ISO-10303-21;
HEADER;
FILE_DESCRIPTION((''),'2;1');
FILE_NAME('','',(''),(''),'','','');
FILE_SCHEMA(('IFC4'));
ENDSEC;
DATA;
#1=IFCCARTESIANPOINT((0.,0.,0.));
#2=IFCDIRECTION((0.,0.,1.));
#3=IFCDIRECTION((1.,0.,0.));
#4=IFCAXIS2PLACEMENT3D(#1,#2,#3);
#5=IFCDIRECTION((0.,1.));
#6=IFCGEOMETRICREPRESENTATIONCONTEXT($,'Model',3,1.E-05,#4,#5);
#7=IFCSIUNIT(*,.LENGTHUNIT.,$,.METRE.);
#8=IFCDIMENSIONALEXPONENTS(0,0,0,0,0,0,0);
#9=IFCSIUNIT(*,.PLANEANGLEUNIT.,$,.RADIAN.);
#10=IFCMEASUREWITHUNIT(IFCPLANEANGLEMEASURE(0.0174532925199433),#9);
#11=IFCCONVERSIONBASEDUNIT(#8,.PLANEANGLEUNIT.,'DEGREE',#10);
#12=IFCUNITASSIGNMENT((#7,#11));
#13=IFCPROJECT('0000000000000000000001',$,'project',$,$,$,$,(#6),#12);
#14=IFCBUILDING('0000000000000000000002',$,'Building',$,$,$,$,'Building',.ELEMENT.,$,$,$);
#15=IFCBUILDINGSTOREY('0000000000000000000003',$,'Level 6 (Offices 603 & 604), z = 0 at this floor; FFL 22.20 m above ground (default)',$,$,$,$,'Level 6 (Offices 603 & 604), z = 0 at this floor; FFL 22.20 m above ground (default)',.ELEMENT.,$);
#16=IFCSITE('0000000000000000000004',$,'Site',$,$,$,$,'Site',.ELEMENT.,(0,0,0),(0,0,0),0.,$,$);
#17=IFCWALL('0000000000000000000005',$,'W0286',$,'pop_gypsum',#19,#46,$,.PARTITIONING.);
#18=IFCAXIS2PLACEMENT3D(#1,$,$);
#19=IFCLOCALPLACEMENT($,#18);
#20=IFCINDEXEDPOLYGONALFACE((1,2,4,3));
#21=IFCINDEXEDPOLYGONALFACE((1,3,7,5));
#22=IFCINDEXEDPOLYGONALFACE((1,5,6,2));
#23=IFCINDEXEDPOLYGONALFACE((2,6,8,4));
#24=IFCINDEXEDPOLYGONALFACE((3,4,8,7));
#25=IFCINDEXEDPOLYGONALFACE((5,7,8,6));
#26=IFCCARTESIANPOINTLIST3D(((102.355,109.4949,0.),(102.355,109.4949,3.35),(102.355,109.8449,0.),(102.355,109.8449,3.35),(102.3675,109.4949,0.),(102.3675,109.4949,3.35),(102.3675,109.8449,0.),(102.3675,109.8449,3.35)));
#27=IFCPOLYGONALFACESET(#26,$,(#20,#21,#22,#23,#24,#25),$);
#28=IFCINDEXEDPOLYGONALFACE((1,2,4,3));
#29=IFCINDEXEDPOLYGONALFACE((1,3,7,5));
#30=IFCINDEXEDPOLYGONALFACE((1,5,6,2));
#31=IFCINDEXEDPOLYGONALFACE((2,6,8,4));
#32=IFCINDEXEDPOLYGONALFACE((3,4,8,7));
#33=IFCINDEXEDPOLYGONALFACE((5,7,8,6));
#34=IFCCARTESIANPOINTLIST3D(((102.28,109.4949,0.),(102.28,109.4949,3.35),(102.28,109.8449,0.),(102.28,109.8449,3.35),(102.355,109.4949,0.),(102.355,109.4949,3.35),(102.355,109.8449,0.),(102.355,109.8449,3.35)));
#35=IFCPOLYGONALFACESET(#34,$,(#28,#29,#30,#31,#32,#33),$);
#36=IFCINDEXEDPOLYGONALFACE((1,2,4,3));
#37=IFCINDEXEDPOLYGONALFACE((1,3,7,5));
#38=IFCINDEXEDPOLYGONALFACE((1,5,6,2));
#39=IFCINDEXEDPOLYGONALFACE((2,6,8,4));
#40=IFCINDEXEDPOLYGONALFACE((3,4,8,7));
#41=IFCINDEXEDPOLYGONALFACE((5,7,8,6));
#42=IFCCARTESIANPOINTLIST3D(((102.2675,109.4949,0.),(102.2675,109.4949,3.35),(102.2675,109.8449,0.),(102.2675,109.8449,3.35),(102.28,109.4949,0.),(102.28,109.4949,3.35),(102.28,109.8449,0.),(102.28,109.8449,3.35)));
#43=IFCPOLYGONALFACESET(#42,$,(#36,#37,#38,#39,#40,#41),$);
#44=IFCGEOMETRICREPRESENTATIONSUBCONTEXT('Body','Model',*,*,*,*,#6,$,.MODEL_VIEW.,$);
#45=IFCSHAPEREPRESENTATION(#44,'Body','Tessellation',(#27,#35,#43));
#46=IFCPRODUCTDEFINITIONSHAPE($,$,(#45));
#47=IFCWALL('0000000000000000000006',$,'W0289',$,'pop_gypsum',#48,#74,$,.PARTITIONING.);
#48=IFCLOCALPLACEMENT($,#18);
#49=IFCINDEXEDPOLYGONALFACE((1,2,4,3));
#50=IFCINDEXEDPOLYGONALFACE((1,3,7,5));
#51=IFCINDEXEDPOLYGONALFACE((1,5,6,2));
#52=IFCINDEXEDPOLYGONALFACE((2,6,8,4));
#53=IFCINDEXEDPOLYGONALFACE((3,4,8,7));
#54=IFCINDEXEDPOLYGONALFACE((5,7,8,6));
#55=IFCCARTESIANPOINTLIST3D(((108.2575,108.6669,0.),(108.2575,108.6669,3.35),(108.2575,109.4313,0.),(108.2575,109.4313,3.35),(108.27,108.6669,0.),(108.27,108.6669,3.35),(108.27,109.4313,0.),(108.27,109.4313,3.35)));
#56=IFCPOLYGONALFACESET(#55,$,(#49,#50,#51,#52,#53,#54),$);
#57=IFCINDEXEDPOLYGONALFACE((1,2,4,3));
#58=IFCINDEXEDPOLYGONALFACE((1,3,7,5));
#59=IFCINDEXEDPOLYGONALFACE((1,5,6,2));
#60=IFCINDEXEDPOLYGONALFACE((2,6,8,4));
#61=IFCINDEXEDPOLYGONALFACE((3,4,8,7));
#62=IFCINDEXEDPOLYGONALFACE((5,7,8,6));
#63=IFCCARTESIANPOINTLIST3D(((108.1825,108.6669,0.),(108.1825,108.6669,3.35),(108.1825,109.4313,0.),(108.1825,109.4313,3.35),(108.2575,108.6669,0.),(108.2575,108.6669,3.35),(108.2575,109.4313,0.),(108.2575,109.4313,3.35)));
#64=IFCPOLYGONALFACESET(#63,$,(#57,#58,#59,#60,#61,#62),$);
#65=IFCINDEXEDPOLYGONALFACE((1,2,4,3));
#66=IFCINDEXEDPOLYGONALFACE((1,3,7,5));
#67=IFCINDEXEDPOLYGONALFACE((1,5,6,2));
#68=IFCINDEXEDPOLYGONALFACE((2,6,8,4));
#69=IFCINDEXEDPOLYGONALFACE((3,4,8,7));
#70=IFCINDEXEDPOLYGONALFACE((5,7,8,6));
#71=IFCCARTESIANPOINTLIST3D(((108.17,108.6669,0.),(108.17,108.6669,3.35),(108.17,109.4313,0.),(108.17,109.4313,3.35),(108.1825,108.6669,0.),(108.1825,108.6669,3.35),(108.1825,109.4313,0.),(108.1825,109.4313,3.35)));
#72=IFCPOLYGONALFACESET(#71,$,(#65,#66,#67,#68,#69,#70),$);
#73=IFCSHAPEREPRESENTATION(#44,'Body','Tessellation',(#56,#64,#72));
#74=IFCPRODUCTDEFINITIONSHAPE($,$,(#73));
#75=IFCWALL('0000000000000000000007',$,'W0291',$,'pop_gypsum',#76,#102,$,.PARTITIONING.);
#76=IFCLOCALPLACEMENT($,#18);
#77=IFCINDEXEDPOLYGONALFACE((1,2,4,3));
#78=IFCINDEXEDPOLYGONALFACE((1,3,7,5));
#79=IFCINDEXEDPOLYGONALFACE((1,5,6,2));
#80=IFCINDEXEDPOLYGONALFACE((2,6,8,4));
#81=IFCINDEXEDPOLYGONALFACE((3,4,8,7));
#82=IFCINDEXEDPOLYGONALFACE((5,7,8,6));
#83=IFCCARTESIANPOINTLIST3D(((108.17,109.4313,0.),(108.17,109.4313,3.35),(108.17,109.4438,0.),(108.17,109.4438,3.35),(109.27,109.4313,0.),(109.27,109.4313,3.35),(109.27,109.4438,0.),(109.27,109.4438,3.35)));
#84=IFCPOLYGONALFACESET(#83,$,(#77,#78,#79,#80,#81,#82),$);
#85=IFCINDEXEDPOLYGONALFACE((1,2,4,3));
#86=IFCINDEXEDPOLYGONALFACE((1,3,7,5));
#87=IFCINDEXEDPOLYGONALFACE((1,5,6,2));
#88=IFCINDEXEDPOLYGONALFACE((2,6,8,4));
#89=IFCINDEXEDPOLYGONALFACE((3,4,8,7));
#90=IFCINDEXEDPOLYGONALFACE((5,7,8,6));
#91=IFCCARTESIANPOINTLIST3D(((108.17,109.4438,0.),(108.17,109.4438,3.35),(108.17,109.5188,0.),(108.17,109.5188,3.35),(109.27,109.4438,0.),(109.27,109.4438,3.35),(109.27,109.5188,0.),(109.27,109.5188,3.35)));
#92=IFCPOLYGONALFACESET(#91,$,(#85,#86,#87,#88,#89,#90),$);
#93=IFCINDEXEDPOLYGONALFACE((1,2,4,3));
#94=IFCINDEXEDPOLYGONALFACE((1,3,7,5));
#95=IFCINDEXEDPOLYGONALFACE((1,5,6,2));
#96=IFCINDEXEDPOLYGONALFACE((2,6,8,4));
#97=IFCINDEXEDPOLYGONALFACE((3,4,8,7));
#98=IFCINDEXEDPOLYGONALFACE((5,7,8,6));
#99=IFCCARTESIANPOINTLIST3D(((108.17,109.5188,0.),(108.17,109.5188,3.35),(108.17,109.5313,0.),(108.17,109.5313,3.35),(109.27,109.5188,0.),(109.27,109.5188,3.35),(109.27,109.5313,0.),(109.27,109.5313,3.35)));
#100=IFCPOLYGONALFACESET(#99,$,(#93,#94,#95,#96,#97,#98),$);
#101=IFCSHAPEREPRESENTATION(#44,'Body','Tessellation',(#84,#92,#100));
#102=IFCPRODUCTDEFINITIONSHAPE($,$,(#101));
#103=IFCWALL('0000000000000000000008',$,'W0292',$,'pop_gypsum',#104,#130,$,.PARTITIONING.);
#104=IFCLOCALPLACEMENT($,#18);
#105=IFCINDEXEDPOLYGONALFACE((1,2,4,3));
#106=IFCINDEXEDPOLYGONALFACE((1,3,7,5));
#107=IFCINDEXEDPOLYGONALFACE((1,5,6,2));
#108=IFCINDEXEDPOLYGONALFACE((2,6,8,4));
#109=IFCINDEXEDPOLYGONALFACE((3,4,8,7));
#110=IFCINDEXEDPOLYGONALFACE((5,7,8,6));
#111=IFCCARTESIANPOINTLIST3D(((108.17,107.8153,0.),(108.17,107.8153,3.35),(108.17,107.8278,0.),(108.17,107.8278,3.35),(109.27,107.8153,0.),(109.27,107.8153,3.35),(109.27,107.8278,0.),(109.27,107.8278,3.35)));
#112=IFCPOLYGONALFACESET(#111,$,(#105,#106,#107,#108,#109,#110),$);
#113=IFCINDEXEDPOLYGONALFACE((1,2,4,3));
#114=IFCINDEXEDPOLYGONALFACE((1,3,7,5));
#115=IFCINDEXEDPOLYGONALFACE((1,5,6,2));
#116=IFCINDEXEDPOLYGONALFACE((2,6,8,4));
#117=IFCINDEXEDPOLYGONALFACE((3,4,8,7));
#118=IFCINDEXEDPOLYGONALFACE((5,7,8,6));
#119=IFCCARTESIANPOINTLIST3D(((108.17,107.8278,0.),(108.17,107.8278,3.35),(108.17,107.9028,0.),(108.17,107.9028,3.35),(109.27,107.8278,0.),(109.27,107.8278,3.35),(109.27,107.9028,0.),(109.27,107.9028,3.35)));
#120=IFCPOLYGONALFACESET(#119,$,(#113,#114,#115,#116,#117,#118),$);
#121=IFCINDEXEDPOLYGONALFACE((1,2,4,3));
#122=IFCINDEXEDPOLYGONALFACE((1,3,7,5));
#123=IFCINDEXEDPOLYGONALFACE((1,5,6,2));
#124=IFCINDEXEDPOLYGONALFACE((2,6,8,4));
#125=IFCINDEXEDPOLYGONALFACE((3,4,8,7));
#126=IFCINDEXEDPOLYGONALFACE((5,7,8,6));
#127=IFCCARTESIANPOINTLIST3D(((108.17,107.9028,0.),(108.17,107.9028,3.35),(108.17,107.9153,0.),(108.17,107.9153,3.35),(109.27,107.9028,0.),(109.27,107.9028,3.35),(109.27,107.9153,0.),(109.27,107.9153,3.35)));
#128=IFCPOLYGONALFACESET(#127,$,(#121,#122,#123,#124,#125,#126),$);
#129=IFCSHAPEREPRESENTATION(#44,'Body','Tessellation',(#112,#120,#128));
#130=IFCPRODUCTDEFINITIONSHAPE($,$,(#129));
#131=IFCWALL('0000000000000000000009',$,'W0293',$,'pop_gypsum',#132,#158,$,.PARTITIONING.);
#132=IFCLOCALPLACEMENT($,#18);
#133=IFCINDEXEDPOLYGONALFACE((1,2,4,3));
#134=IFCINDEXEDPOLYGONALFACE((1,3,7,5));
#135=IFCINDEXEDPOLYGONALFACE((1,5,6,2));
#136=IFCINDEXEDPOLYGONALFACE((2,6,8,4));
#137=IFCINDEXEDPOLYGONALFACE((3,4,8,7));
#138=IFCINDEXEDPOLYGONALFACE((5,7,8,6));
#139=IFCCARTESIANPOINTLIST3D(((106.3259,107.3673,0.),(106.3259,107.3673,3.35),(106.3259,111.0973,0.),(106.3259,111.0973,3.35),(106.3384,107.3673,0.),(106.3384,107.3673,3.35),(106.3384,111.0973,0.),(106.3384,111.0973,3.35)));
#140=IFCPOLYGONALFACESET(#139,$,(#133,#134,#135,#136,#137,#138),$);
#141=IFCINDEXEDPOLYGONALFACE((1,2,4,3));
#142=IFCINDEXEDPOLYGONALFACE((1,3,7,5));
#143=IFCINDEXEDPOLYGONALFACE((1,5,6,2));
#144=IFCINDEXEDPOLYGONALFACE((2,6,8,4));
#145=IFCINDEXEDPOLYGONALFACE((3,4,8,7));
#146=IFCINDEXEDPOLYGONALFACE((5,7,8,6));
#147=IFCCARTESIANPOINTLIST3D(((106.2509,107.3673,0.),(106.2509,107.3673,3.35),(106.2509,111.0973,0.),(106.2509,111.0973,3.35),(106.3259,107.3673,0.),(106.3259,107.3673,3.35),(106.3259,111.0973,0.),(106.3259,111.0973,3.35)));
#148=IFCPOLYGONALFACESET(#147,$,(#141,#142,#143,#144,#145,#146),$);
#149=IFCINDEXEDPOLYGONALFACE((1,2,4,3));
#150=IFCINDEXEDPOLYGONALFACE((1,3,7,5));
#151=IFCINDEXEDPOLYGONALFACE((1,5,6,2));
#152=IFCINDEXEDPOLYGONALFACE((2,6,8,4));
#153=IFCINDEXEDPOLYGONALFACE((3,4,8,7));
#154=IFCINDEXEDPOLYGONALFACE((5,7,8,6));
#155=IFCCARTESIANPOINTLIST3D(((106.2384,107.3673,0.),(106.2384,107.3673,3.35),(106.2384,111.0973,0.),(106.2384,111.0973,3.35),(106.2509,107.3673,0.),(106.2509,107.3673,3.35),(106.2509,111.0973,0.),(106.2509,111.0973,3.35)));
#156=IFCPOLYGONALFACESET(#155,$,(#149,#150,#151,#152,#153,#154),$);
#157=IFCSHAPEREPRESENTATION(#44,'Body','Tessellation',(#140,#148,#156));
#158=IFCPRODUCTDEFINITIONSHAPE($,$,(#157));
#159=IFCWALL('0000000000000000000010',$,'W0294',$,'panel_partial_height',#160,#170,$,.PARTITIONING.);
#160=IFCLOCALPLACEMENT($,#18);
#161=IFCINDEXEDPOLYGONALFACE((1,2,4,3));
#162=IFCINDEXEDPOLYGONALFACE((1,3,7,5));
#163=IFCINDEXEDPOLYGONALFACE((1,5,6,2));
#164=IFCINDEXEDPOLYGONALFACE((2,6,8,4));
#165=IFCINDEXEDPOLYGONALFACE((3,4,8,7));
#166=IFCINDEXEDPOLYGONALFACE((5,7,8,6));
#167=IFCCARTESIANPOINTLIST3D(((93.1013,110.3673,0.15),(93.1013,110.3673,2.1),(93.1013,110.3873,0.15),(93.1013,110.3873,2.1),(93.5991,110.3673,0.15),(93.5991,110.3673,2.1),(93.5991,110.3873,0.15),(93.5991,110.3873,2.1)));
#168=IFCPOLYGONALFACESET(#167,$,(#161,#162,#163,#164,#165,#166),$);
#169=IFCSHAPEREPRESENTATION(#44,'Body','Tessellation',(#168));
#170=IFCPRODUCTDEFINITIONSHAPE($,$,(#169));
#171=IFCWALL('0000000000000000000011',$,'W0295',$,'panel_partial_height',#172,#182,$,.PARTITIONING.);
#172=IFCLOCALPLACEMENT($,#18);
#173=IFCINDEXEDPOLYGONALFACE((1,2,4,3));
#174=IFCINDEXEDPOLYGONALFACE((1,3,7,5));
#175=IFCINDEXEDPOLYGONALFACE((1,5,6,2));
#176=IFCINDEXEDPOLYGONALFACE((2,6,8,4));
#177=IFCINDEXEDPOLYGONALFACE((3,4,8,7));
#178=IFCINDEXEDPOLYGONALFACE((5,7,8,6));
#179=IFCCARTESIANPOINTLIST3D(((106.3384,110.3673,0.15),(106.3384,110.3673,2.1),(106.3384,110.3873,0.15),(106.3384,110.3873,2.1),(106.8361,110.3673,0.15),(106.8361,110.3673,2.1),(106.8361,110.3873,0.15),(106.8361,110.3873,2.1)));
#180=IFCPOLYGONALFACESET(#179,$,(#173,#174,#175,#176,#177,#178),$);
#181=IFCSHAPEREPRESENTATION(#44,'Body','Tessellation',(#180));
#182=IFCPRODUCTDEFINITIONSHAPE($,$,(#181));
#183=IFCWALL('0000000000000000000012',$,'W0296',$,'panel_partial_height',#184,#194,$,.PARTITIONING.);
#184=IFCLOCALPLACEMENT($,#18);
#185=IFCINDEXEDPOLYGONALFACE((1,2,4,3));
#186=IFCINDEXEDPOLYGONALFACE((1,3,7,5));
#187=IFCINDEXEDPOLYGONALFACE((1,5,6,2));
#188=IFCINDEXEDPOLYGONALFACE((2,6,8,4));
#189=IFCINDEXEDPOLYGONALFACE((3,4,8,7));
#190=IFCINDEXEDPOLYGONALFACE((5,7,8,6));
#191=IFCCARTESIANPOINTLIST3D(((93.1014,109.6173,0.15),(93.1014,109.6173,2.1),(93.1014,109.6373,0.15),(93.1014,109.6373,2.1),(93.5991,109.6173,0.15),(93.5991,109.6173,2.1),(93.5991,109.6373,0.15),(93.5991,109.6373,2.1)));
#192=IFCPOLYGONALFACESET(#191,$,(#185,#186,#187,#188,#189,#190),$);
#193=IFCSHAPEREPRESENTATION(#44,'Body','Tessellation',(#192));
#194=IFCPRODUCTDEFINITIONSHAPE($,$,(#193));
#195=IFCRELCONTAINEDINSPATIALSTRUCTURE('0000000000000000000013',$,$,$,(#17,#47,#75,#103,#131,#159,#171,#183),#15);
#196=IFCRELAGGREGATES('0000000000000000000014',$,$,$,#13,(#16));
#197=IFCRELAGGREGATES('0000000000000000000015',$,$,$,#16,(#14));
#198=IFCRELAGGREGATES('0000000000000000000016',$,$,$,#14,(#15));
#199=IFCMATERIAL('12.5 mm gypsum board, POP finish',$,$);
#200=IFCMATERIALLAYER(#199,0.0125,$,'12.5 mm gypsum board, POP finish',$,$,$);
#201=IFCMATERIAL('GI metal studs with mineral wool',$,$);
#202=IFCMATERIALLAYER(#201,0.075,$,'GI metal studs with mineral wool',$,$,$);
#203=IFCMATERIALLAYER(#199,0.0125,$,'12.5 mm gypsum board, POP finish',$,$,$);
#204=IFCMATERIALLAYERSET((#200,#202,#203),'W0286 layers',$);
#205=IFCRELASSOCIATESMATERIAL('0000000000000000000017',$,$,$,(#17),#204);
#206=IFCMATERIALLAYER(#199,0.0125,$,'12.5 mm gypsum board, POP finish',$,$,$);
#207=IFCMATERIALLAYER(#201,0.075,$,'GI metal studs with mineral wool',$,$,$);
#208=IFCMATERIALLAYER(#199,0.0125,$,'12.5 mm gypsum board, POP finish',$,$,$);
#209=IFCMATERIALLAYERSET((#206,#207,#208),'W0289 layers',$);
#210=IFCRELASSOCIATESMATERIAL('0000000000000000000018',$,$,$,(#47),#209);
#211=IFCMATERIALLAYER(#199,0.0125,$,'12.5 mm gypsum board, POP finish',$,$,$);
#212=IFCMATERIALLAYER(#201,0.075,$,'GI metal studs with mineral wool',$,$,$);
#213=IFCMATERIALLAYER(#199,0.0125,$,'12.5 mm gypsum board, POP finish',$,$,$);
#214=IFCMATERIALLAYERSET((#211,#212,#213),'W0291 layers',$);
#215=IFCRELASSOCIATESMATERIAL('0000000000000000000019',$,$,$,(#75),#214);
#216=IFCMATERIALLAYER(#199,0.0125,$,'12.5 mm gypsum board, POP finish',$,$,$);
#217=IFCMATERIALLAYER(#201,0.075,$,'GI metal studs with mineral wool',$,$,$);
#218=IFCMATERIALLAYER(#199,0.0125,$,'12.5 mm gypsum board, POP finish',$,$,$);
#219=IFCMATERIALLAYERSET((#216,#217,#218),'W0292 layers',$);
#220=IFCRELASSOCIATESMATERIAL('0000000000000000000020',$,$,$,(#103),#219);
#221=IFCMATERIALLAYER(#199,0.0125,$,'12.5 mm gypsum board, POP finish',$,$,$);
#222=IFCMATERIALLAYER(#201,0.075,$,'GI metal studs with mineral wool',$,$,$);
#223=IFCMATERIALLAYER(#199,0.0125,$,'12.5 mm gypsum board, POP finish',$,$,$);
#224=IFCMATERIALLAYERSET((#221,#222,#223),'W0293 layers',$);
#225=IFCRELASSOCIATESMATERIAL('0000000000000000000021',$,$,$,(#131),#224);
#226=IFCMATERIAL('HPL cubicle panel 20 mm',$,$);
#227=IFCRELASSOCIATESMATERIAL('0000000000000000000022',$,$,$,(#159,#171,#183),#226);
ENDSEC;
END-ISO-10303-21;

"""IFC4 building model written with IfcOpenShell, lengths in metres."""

from ifc_helpers import new_model, entity, si_unit, converted_unit, direction, frame, frame_2d, origin_with_axes, origin_2d_with_axis, place, context, subcontext, project, spatial, rectangle, extrude, material, layer, layer_set, layer_usage, element, save


model = new_model("IFC4")

# Units and contexts
model_context = context("Model", 3, precision=1e-05, world=origin_with_axes(), true_north=direction((0.0, 1.0)))
body_context = subcontext(model_context, "Body", "Model", "MODEL_VIEW")
ifc_project = project(units=[si_unit("LENGTHUNIT", "METRE"), converted_unit("PLANEANGLEUNIT", "DEGREE", entity("IfcPlaneAngleMeasure", 0.0174532925199433), si_unit("PLANEANGLEUNIT", "RADIAN"), dimensions=[0, 0, 0, 0, 0, 0, 0])], contexts=[model_context])

# Site, building, storey
site = spatial("IfcSite", under=ifc_project, Name="Site", LongName="Site", CompositionType="ELEMENT", RefLatitude=(0, 0, 0), RefLongitude=(0, 0, 0), RefElevation=0.0)
building = spatial("IfcBuilding", under=site, Name="Building", LongName="Building", CompositionType="ELEMENT")
storey = spatial("IfcBuildingStorey", under=building, Name="Level 6 (Offices 603 & 604), z = 0 at this floor; FFL 22.20 m above ground (default)", LongName="Level 6 (Offices 603 & 604), z = 0 at this floor; FFL 22.20 m above ground (default)", CompositionType="ELEMENT")

# Walls
ifc_material_1 = material(Name="12.5 mm gypsum board, POP finish")
ifc_layer_1 = layer(ifc_material_1, 0.0125, Name="12.5 mm gypsum board, POP finish")
ifc_material_2 = material(Name="GI metal studs with mineral wool")
ifc_layer_2 = layer(ifc_material_2, 0.075, Name="GI metal studs with mineral wool")
ifc_layer_3 = layer(ifc_material_1, 0.0125, Name="12.5 mm gypsum board, POP finish")
ifc_layer_set_1 = layer_set([ifc_layer_1, ifc_layer_2, ifc_layer_3], Name="W0286 layers")
ifc_layer_usage_1 = layer_usage(ifc_layer_set_1, "AXIS2", "POSITIVE", -0.05)
placement = place(None, origin_with_axes())
element("IfcWall", 1, at=placement, inside=storey, material=ifc_layer_usage_1, Name="W0286", ObjectType="pop_gypsum", PredefinedType="PARTITIONING", context=body_context, shape_type="SweptSolid", body=[
    extrude(rectangle(XDim=0.35, YDim=0.0125, at=frame_2d((0.0, 0.0), x_axis=(0.0, 1.0))), frame((102.3612, 109.6699, 0.0), z_axis=(0.0, 0.0, 1.0), x_axis=(1.0, 0.0, 0.0)), (0.0, 0.0, 1.0), 3.35),
    extrude(rectangle(XDim=0.35, YDim=0.075, at=frame_2d((-0.0438, 0.0), x_axis=(0.0, 1.0))), frame((102.3612, 109.6699, 0.0), z_axis=(0.0, 0.0, 1.0), x_axis=(1.0, 0.0, 0.0)), (0.0, 0.0, 1.0), 3.35),
    extrude(rectangle(XDim=0.35, YDim=0.0125, at=frame_2d((-0.0875, 0.0), x_axis=(0.0, 1.0))), frame((102.3612, 109.6699, 0.0), z_axis=(0.0, 0.0, 1.0), x_axis=(1.0, 0.0, 0.0)), (0.0, 0.0, 1.0), 3.35),
])
ifc_layer_4 = layer(ifc_material_1, 0.0125, Name="12.5 mm gypsum board, POP finish")
ifc_layer_5 = layer(ifc_material_2, 0.075, Name="GI metal studs with mineral wool")
ifc_layer_6 = layer(ifc_material_1, 0.0125, Name="12.5 mm gypsum board, POP finish")
ifc_layer_set_2 = layer_set([ifc_layer_4, ifc_layer_5, ifc_layer_6], Name="W0289 layers")
ifc_layer_usage_2 = layer_usage(ifc_layer_set_2, "AXIS2", "POSITIVE", -0.05)
element("IfcWall", 2, at=placement, inside=storey, material=ifc_layer_usage_2, Name="W0289", ObjectType="pop_gypsum", PredefinedType="PARTITIONING", context=body_context, shape_type="SweptSolid", body=[
    extrude(rectangle(XDim=0.7644, YDim=0.0125, at=frame_2d((0.0, 0.0), x_axis=(0.0, 1.0))), frame((108.2638, 109.0491, 0.0), z_axis=(0.0, 0.0, 1.0), x_axis=(1.0, 0.0, 0.0)), (0.0, 0.0, 1.0), 3.35),
    extrude(rectangle(XDim=0.7644, YDim=0.075, at=frame_2d((-0.0437, 0.0), x_axis=(0.0, 1.0))), frame((108.2638, 109.0491, 0.0), z_axis=(0.0, 0.0, 1.0), x_axis=(1.0, 0.0, 0.0)), (0.0, 0.0, 1.0), 3.35),
    extrude(rectangle(XDim=0.7644, YDim=0.0125, at=frame_2d((-0.0875, 0.0), x_axis=(0.0, 1.0))), frame((108.2638, 109.0491, 0.0), z_axis=(0.0, 0.0, 1.0), x_axis=(1.0, 0.0, 0.0)), (0.0, 0.0, 1.0), 3.35),
])
ifc_layer_7 = layer(ifc_material_1, 0.0125, Name="12.5 mm gypsum board, POP finish")
ifc_layer_8 = layer(ifc_material_2, 0.075, Name="GI metal studs with mineral wool")
ifc_layer_9 = layer(ifc_material_1, 0.0125, Name="12.5 mm gypsum board, POP finish")
ifc_layer_set_3 = layer_set([ifc_layer_7, ifc_layer_8, ifc_layer_9], Name="W0291 layers")
ifc_layer_usage_3 = layer_usage(ifc_layer_set_3, "AXIS2", "POSITIVE", -0.05)
element("IfcWall", 3, at=placement, inside=storey, material=ifc_layer_usage_3, Name="W0291", ObjectType="pop_gypsum", PredefinedType="PARTITIONING", context=body_context, shape_type="SweptSolid", body=[
    extrude(rectangle(XDim=1.1, YDim=0.0125, at=origin_2d_with_axis()), frame((108.72, 109.4376, 0.0), z_axis=(0.0, 0.0, 1.0), x_axis=(1.0, 0.0, 0.0)), (0.0, 0.0, 1.0), 3.35),
    extrude(rectangle(XDim=1.1, YDim=0.075, at=frame_2d((0.0, 0.0437), x_axis=(1.0, 0.0))), frame((108.72, 109.4376, 0.0), z_axis=(0.0, 0.0, 1.0), x_axis=(1.0, 0.0, 0.0)), (0.0, 0.0, 1.0), 3.35),
    extrude(rectangle(XDim=1.1, YDim=0.0125, at=frame_2d((0.0, 0.0875), x_axis=(1.0, 0.0))), frame((108.72, 109.4376, 0.0), z_axis=(0.0, 0.0, 1.0), x_axis=(1.0, 0.0, 0.0)), (0.0, 0.0, 1.0), 3.35),
])
ifc_layer_10 = layer(ifc_material_1, 0.0125, Name="12.5 mm gypsum board, POP finish")
ifc_layer_11 = layer(ifc_material_2, 0.075, Name="GI metal studs with mineral wool")
ifc_layer_12 = layer(ifc_material_1, 0.0125, Name="12.5 mm gypsum board, POP finish")
ifc_layer_set_4 = layer_set([ifc_layer_10, ifc_layer_11, ifc_layer_12], Name="W0292 layers")
ifc_layer_usage_4 = layer_usage(ifc_layer_set_4, "AXIS2", "POSITIVE", -0.05)
element("IfcWall", 4, at=placement, inside=storey, material=ifc_layer_usage_4, Name="W0292", ObjectType="pop_gypsum", PredefinedType="PARTITIONING", context=body_context, shape_type="SweptSolid", body=[
    extrude(rectangle(XDim=1.1, YDim=0.0125, at=origin_2d_with_axis()), frame((108.72, 107.8216, 0.0), z_axis=(0.0, 0.0, 1.0), x_axis=(1.0, 0.0, 0.0)), (0.0, 0.0, 1.0), 3.35),
    extrude(rectangle(XDim=1.1, YDim=0.075, at=frame_2d((0.0, 0.0437), x_axis=(1.0, 0.0))), frame((108.72, 107.8216, 0.0), z_axis=(0.0, 0.0, 1.0), x_axis=(1.0, 0.0, 0.0)), (0.0, 0.0, 1.0), 3.35),
    extrude(rectangle(XDim=1.1, YDim=0.0125, at=frame_2d((0.0, 0.0875), x_axis=(1.0, 0.0))), frame((108.72, 107.8216, 0.0), z_axis=(0.0, 0.0, 1.0), x_axis=(1.0, 0.0, 0.0)), (0.0, 0.0, 1.0), 3.35),
])
ifc_layer_13 = layer(ifc_material_1, 0.0125, Name="12.5 mm gypsum board, POP finish")
ifc_layer_14 = layer(ifc_material_2, 0.075, Name="GI metal studs with mineral wool")
ifc_layer_15 = layer(ifc_material_1, 0.0125, Name="12.5 mm gypsum board, POP finish")
ifc_layer_set_5 = layer_set([ifc_layer_13, ifc_layer_14, ifc_layer_15], Name="W0293 layers")
ifc_layer_usage_5 = layer_usage(ifc_layer_set_5, "AXIS2", "POSITIVE", -0.05)
element("IfcWall", 5, at=placement, inside=storey, material=ifc_layer_usage_5, Name="W0293", ObjectType="pop_gypsum", PredefinedType="PARTITIONING", context=body_context, shape_type="SweptSolid", body=[
    extrude(rectangle(XDim=3.73, YDim=0.0125, at=frame_2d((0.0, 0.0), x_axis=(0.0, 1.0))), frame((106.3321, 109.2323, 0.0), z_axis=(0.0, 0.0, 1.0), x_axis=(1.0, 0.0, 0.0)), (0.0, 0.0, 1.0), 3.35),
    extrude(rectangle(XDim=3.73, YDim=0.075, at=frame_2d((-0.0437, 0.0), x_axis=(0.0, 1.0))), frame((106.3321, 109.2323, 0.0), z_axis=(0.0, 0.0, 1.0), x_axis=(1.0, 0.0, 0.0)), (0.0, 0.0, 1.0), 3.35),
    extrude(rectangle(XDim=3.73, YDim=0.0125, at=frame_2d((-0.0875, 0.0), x_axis=(0.0, 1.0))), frame((106.3321, 109.2323, 0.0), z_axis=(0.0, 0.0, 1.0), x_axis=(1.0, 0.0, 0.0)), (0.0, 0.0, 1.0), 3.35),
])
ifc_material_3 = material(Name="HPL cubicle panel 20 mm")
element("IfcWall", 6, at=placement, inside=storey, material=ifc_material_3, Name="W0294", ObjectType="panel_partial_height", PredefinedType="PARTITIONING", context=body_context, shape_type="SweptSolid", body=[
    extrude(rectangle(XDim=0.4978, YDim=0.02, at=origin_2d_with_axis()), frame((93.3502, 110.3773, 0.15), z_axis=(0.0, 0.0, 1.0), x_axis=(1.0, 0.0, 0.0)), (0.0, 0.0, 1.0), 1.95),
])
element("IfcWall", 7, at=placement, inside=storey, material=ifc_material_3, Name="W0295", ObjectType="panel_partial_height", PredefinedType="PARTITIONING", context=body_context, shape_type="SweptSolid", body=[
    extrude(rectangle(XDim=0.4977, YDim=0.02, at=frame_2d((0.0, 0.0), x_axis=(1.0, 0.0))), frame((106.5872, 110.3773, 0.15), z_axis=(0.0, 0.0, 1.0), x_axis=(1.0, 0.0, 0.0)), (0.0, 0.0, 1.0), 1.95),
])
element("IfcWall", 8, at=placement, inside=storey, material=ifc_material_3, Name="W0296", ObjectType="panel_partial_height", PredefinedType="PARTITIONING", context=body_context, shape_type="SweptSolid", body=[
    extrude(rectangle(XDim=0.4977, YDim=0.02, at=frame_2d((0.0, 0.0), x_axis=(1.0, 0.0))), frame((93.3503, 109.6273, 0.15), z_axis=(0.0, 0.0, 1.0), x_axis=(1.0, 0.0, 0.0)), (0.0, 0.0, 1.0), 1.95),
])

save(model, "model.ifc")
